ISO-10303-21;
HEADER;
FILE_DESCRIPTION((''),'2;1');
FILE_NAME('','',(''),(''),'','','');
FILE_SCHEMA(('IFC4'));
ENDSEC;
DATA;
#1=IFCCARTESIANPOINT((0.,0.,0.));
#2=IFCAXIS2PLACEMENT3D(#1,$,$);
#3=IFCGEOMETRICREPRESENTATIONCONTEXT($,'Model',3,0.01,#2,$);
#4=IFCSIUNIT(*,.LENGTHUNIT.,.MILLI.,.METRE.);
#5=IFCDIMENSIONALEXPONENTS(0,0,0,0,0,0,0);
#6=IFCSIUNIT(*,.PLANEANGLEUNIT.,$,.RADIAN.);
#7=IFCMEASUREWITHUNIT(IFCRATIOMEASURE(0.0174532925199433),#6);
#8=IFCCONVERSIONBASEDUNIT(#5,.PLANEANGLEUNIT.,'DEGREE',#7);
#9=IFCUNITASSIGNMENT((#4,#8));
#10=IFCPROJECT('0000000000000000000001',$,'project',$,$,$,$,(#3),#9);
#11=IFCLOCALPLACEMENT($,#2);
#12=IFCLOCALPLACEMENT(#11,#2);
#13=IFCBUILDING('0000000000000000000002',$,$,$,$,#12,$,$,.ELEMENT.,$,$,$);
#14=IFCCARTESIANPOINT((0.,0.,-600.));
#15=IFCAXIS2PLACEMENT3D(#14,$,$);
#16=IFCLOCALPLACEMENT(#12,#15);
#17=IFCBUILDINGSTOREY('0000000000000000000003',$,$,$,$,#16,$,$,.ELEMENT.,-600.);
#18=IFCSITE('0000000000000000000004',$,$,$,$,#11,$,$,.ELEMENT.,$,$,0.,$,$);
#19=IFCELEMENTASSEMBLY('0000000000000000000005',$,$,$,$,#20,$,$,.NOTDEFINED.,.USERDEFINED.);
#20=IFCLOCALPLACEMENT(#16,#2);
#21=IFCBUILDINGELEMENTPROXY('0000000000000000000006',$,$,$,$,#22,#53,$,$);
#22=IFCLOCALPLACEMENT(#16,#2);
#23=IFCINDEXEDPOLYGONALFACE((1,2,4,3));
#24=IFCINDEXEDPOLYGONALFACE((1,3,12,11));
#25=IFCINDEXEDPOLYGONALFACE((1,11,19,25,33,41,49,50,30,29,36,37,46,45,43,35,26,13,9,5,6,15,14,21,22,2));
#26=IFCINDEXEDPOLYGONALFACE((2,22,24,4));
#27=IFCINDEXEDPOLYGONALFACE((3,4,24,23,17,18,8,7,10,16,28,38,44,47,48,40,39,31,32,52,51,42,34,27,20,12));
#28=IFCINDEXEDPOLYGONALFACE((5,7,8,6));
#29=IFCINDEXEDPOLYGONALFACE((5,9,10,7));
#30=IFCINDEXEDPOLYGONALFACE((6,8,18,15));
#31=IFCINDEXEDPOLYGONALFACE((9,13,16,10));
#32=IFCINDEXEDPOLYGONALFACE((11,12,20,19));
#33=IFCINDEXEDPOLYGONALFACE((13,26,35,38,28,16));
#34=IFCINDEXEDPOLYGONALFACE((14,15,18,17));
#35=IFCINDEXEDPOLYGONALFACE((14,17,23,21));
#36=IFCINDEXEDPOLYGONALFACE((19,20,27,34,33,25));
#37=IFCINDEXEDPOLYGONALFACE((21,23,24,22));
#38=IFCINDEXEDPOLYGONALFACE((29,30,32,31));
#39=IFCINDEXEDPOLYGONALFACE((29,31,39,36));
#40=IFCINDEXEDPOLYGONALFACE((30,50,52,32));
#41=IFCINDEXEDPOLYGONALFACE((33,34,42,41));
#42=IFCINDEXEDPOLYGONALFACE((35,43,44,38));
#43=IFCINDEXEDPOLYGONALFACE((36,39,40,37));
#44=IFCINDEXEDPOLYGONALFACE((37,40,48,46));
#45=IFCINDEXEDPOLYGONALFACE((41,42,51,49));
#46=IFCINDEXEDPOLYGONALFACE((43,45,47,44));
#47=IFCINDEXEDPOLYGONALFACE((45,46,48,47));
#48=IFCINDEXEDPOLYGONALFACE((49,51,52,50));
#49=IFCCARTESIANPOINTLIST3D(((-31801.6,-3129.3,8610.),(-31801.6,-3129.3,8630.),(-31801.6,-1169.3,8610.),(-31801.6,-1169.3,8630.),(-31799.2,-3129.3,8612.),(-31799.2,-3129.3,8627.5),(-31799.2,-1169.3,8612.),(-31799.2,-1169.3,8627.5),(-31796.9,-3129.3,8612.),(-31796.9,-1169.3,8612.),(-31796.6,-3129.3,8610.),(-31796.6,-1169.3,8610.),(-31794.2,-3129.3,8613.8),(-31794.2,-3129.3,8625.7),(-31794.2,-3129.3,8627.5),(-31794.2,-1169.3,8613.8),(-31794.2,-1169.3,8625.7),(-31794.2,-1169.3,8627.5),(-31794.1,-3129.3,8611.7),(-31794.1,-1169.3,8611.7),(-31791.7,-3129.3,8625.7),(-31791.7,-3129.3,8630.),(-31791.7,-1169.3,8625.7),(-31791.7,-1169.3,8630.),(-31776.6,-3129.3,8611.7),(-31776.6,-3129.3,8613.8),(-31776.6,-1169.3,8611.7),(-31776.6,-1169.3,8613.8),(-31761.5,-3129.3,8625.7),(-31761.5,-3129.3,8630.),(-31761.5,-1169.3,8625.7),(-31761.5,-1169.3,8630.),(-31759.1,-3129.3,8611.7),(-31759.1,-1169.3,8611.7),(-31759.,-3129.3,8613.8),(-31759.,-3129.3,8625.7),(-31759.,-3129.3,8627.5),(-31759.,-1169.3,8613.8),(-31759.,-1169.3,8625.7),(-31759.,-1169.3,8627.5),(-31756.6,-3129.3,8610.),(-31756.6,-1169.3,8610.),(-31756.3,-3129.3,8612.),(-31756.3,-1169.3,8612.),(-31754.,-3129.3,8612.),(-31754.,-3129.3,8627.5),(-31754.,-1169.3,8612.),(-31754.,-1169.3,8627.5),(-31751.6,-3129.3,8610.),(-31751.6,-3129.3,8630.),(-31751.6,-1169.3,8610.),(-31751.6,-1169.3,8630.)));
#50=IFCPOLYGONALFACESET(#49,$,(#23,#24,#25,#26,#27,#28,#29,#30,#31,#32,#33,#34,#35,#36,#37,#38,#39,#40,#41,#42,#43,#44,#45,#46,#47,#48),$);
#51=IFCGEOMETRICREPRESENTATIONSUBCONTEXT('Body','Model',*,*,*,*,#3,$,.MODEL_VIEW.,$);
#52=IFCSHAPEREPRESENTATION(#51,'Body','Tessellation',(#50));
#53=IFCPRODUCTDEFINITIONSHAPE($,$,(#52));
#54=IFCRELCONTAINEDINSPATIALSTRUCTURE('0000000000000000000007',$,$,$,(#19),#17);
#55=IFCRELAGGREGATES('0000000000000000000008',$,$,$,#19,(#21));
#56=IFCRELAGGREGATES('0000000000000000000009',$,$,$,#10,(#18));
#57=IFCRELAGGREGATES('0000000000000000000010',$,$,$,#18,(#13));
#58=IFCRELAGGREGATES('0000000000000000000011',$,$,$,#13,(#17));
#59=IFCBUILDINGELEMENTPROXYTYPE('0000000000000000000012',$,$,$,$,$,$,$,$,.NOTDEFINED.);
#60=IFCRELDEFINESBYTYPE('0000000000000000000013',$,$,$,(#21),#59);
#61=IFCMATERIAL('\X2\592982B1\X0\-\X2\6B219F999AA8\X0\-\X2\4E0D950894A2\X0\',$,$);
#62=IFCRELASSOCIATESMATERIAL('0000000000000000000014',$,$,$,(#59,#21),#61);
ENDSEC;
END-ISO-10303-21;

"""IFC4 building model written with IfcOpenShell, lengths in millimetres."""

from ifc_helpers import new_model, entity, si_unit, converted_unit, frame, origin, place, context, subcontext, project, spatial, polyline, outline, extrude, source, transform, mapped, material, type_object, type_shapes, element, aggregate, save


model = new_model("IFC4")

# Units and contexts
model_context = context("Model", 3, precision=0.01, world=origin())
body_context = subcontext(model_context, "Body", "Model", "MODEL_VIEW")
ifc_project = project(units=[si_unit("LENGTHUNIT", "METRE", prefix="MILLI"), converted_unit("PLANEANGLEUNIT", "DEGREE", entity("IfcRatioMeasure", 0.0174532925199433), si_unit("PLANEANGLEUNIT", "RADIAN"), dimensions=[0, 0, 0, 0, 0, 0, 0])], contexts=[model_context])

# Site, building, storey
site_placement = place(None, origin())
site = spatial("IfcSite", under=ifc_project, at=site_placement, CompositionType="ELEMENT", RefElevation=0.0)
building_placement = place(site_placement, origin())
building = spatial("IfcBuilding", under=site, at=building_placement, CompositionType="ELEMENT")
storey_placement = place(building_placement, frame((0.0, 0.0, -600.0)))
storey = spatial("IfcBuildingStorey", under=building, at=storey_placement, CompositionType="ELEMENT", Elevation=-600.0)

# Element assembly, building element proxy
assembly_placement = place(storey_placement, origin())
assembly = element("IfcElementAssembly", 1, at=assembly_placement, inside=storey, AssemblyPlace="NOTDEFINED", PredefinedType="USERDEFINED")
ifc_material_1 = material(Name="天花-次龙骨-不锈钢")
building_element_proxy_type_1 = type_object("IfcBuildingElementProxyType", PredefinedType="NOTDEFINED", material=ifc_material_1)
shared_shape_1 = source(origin(), body_context, "Body", "SweptSolid", [
    extrude(outline(polyline([(-25.0, -9.1), (-20.0, -9.1), (-17.5, -7.4), (0.0, -7.4), (17.5, -7.4), (20.0, -9.1), (25.0, -9.1), (25.0, 10.9), (15.1, 10.9), (15.1, 6.6), (17.6, 6.6), (17.6, 8.4), (22.6, 8.4), (22.6, -7.1), (20.3, -7.1), (17.6, -5.3), (0.0, -5.3), (-17.6, -5.3), (-20.3, -7.1), (-22.6, -7.1), (-22.6, 8.4), (-17.6, 8.4), (-17.6, 6.6), (-15.1, 6.6), (-15.1, 10.9), (-25.0, 10.9), (-25.0, -9.1)])), frame((0.0, 0.0, -0.9), z_axis=(1.0, 0.0, 0.0), x_axis=(0.0, 1.0, 0.0)), (0.0, 0.0, 1.0), 1960.0),
])
type_shapes(building_element_proxy_type_1, [shared_shape_1])
proxy_1_placement = place(assembly_placement, frame((-31776.6, -1169.3, 8620.0), z_axis=(0.0, 0.0, 1.0), x_axis=(0.0, -1.0, 0.0)))
proxy_1 = element("IfcBuildingElementProxy", 2, at=proxy_1_placement, type_object=building_element_proxy_type_1, material=ifc_material_1, context=body_context, shape_type="MappedRepresentation", body=[
    mapped(shared_shape_1, transform((0.0, 0.0, 0.0), scale=1.0)),
])
aggregate(assembly, [proxy_1])

save(model, "model.ifc")
